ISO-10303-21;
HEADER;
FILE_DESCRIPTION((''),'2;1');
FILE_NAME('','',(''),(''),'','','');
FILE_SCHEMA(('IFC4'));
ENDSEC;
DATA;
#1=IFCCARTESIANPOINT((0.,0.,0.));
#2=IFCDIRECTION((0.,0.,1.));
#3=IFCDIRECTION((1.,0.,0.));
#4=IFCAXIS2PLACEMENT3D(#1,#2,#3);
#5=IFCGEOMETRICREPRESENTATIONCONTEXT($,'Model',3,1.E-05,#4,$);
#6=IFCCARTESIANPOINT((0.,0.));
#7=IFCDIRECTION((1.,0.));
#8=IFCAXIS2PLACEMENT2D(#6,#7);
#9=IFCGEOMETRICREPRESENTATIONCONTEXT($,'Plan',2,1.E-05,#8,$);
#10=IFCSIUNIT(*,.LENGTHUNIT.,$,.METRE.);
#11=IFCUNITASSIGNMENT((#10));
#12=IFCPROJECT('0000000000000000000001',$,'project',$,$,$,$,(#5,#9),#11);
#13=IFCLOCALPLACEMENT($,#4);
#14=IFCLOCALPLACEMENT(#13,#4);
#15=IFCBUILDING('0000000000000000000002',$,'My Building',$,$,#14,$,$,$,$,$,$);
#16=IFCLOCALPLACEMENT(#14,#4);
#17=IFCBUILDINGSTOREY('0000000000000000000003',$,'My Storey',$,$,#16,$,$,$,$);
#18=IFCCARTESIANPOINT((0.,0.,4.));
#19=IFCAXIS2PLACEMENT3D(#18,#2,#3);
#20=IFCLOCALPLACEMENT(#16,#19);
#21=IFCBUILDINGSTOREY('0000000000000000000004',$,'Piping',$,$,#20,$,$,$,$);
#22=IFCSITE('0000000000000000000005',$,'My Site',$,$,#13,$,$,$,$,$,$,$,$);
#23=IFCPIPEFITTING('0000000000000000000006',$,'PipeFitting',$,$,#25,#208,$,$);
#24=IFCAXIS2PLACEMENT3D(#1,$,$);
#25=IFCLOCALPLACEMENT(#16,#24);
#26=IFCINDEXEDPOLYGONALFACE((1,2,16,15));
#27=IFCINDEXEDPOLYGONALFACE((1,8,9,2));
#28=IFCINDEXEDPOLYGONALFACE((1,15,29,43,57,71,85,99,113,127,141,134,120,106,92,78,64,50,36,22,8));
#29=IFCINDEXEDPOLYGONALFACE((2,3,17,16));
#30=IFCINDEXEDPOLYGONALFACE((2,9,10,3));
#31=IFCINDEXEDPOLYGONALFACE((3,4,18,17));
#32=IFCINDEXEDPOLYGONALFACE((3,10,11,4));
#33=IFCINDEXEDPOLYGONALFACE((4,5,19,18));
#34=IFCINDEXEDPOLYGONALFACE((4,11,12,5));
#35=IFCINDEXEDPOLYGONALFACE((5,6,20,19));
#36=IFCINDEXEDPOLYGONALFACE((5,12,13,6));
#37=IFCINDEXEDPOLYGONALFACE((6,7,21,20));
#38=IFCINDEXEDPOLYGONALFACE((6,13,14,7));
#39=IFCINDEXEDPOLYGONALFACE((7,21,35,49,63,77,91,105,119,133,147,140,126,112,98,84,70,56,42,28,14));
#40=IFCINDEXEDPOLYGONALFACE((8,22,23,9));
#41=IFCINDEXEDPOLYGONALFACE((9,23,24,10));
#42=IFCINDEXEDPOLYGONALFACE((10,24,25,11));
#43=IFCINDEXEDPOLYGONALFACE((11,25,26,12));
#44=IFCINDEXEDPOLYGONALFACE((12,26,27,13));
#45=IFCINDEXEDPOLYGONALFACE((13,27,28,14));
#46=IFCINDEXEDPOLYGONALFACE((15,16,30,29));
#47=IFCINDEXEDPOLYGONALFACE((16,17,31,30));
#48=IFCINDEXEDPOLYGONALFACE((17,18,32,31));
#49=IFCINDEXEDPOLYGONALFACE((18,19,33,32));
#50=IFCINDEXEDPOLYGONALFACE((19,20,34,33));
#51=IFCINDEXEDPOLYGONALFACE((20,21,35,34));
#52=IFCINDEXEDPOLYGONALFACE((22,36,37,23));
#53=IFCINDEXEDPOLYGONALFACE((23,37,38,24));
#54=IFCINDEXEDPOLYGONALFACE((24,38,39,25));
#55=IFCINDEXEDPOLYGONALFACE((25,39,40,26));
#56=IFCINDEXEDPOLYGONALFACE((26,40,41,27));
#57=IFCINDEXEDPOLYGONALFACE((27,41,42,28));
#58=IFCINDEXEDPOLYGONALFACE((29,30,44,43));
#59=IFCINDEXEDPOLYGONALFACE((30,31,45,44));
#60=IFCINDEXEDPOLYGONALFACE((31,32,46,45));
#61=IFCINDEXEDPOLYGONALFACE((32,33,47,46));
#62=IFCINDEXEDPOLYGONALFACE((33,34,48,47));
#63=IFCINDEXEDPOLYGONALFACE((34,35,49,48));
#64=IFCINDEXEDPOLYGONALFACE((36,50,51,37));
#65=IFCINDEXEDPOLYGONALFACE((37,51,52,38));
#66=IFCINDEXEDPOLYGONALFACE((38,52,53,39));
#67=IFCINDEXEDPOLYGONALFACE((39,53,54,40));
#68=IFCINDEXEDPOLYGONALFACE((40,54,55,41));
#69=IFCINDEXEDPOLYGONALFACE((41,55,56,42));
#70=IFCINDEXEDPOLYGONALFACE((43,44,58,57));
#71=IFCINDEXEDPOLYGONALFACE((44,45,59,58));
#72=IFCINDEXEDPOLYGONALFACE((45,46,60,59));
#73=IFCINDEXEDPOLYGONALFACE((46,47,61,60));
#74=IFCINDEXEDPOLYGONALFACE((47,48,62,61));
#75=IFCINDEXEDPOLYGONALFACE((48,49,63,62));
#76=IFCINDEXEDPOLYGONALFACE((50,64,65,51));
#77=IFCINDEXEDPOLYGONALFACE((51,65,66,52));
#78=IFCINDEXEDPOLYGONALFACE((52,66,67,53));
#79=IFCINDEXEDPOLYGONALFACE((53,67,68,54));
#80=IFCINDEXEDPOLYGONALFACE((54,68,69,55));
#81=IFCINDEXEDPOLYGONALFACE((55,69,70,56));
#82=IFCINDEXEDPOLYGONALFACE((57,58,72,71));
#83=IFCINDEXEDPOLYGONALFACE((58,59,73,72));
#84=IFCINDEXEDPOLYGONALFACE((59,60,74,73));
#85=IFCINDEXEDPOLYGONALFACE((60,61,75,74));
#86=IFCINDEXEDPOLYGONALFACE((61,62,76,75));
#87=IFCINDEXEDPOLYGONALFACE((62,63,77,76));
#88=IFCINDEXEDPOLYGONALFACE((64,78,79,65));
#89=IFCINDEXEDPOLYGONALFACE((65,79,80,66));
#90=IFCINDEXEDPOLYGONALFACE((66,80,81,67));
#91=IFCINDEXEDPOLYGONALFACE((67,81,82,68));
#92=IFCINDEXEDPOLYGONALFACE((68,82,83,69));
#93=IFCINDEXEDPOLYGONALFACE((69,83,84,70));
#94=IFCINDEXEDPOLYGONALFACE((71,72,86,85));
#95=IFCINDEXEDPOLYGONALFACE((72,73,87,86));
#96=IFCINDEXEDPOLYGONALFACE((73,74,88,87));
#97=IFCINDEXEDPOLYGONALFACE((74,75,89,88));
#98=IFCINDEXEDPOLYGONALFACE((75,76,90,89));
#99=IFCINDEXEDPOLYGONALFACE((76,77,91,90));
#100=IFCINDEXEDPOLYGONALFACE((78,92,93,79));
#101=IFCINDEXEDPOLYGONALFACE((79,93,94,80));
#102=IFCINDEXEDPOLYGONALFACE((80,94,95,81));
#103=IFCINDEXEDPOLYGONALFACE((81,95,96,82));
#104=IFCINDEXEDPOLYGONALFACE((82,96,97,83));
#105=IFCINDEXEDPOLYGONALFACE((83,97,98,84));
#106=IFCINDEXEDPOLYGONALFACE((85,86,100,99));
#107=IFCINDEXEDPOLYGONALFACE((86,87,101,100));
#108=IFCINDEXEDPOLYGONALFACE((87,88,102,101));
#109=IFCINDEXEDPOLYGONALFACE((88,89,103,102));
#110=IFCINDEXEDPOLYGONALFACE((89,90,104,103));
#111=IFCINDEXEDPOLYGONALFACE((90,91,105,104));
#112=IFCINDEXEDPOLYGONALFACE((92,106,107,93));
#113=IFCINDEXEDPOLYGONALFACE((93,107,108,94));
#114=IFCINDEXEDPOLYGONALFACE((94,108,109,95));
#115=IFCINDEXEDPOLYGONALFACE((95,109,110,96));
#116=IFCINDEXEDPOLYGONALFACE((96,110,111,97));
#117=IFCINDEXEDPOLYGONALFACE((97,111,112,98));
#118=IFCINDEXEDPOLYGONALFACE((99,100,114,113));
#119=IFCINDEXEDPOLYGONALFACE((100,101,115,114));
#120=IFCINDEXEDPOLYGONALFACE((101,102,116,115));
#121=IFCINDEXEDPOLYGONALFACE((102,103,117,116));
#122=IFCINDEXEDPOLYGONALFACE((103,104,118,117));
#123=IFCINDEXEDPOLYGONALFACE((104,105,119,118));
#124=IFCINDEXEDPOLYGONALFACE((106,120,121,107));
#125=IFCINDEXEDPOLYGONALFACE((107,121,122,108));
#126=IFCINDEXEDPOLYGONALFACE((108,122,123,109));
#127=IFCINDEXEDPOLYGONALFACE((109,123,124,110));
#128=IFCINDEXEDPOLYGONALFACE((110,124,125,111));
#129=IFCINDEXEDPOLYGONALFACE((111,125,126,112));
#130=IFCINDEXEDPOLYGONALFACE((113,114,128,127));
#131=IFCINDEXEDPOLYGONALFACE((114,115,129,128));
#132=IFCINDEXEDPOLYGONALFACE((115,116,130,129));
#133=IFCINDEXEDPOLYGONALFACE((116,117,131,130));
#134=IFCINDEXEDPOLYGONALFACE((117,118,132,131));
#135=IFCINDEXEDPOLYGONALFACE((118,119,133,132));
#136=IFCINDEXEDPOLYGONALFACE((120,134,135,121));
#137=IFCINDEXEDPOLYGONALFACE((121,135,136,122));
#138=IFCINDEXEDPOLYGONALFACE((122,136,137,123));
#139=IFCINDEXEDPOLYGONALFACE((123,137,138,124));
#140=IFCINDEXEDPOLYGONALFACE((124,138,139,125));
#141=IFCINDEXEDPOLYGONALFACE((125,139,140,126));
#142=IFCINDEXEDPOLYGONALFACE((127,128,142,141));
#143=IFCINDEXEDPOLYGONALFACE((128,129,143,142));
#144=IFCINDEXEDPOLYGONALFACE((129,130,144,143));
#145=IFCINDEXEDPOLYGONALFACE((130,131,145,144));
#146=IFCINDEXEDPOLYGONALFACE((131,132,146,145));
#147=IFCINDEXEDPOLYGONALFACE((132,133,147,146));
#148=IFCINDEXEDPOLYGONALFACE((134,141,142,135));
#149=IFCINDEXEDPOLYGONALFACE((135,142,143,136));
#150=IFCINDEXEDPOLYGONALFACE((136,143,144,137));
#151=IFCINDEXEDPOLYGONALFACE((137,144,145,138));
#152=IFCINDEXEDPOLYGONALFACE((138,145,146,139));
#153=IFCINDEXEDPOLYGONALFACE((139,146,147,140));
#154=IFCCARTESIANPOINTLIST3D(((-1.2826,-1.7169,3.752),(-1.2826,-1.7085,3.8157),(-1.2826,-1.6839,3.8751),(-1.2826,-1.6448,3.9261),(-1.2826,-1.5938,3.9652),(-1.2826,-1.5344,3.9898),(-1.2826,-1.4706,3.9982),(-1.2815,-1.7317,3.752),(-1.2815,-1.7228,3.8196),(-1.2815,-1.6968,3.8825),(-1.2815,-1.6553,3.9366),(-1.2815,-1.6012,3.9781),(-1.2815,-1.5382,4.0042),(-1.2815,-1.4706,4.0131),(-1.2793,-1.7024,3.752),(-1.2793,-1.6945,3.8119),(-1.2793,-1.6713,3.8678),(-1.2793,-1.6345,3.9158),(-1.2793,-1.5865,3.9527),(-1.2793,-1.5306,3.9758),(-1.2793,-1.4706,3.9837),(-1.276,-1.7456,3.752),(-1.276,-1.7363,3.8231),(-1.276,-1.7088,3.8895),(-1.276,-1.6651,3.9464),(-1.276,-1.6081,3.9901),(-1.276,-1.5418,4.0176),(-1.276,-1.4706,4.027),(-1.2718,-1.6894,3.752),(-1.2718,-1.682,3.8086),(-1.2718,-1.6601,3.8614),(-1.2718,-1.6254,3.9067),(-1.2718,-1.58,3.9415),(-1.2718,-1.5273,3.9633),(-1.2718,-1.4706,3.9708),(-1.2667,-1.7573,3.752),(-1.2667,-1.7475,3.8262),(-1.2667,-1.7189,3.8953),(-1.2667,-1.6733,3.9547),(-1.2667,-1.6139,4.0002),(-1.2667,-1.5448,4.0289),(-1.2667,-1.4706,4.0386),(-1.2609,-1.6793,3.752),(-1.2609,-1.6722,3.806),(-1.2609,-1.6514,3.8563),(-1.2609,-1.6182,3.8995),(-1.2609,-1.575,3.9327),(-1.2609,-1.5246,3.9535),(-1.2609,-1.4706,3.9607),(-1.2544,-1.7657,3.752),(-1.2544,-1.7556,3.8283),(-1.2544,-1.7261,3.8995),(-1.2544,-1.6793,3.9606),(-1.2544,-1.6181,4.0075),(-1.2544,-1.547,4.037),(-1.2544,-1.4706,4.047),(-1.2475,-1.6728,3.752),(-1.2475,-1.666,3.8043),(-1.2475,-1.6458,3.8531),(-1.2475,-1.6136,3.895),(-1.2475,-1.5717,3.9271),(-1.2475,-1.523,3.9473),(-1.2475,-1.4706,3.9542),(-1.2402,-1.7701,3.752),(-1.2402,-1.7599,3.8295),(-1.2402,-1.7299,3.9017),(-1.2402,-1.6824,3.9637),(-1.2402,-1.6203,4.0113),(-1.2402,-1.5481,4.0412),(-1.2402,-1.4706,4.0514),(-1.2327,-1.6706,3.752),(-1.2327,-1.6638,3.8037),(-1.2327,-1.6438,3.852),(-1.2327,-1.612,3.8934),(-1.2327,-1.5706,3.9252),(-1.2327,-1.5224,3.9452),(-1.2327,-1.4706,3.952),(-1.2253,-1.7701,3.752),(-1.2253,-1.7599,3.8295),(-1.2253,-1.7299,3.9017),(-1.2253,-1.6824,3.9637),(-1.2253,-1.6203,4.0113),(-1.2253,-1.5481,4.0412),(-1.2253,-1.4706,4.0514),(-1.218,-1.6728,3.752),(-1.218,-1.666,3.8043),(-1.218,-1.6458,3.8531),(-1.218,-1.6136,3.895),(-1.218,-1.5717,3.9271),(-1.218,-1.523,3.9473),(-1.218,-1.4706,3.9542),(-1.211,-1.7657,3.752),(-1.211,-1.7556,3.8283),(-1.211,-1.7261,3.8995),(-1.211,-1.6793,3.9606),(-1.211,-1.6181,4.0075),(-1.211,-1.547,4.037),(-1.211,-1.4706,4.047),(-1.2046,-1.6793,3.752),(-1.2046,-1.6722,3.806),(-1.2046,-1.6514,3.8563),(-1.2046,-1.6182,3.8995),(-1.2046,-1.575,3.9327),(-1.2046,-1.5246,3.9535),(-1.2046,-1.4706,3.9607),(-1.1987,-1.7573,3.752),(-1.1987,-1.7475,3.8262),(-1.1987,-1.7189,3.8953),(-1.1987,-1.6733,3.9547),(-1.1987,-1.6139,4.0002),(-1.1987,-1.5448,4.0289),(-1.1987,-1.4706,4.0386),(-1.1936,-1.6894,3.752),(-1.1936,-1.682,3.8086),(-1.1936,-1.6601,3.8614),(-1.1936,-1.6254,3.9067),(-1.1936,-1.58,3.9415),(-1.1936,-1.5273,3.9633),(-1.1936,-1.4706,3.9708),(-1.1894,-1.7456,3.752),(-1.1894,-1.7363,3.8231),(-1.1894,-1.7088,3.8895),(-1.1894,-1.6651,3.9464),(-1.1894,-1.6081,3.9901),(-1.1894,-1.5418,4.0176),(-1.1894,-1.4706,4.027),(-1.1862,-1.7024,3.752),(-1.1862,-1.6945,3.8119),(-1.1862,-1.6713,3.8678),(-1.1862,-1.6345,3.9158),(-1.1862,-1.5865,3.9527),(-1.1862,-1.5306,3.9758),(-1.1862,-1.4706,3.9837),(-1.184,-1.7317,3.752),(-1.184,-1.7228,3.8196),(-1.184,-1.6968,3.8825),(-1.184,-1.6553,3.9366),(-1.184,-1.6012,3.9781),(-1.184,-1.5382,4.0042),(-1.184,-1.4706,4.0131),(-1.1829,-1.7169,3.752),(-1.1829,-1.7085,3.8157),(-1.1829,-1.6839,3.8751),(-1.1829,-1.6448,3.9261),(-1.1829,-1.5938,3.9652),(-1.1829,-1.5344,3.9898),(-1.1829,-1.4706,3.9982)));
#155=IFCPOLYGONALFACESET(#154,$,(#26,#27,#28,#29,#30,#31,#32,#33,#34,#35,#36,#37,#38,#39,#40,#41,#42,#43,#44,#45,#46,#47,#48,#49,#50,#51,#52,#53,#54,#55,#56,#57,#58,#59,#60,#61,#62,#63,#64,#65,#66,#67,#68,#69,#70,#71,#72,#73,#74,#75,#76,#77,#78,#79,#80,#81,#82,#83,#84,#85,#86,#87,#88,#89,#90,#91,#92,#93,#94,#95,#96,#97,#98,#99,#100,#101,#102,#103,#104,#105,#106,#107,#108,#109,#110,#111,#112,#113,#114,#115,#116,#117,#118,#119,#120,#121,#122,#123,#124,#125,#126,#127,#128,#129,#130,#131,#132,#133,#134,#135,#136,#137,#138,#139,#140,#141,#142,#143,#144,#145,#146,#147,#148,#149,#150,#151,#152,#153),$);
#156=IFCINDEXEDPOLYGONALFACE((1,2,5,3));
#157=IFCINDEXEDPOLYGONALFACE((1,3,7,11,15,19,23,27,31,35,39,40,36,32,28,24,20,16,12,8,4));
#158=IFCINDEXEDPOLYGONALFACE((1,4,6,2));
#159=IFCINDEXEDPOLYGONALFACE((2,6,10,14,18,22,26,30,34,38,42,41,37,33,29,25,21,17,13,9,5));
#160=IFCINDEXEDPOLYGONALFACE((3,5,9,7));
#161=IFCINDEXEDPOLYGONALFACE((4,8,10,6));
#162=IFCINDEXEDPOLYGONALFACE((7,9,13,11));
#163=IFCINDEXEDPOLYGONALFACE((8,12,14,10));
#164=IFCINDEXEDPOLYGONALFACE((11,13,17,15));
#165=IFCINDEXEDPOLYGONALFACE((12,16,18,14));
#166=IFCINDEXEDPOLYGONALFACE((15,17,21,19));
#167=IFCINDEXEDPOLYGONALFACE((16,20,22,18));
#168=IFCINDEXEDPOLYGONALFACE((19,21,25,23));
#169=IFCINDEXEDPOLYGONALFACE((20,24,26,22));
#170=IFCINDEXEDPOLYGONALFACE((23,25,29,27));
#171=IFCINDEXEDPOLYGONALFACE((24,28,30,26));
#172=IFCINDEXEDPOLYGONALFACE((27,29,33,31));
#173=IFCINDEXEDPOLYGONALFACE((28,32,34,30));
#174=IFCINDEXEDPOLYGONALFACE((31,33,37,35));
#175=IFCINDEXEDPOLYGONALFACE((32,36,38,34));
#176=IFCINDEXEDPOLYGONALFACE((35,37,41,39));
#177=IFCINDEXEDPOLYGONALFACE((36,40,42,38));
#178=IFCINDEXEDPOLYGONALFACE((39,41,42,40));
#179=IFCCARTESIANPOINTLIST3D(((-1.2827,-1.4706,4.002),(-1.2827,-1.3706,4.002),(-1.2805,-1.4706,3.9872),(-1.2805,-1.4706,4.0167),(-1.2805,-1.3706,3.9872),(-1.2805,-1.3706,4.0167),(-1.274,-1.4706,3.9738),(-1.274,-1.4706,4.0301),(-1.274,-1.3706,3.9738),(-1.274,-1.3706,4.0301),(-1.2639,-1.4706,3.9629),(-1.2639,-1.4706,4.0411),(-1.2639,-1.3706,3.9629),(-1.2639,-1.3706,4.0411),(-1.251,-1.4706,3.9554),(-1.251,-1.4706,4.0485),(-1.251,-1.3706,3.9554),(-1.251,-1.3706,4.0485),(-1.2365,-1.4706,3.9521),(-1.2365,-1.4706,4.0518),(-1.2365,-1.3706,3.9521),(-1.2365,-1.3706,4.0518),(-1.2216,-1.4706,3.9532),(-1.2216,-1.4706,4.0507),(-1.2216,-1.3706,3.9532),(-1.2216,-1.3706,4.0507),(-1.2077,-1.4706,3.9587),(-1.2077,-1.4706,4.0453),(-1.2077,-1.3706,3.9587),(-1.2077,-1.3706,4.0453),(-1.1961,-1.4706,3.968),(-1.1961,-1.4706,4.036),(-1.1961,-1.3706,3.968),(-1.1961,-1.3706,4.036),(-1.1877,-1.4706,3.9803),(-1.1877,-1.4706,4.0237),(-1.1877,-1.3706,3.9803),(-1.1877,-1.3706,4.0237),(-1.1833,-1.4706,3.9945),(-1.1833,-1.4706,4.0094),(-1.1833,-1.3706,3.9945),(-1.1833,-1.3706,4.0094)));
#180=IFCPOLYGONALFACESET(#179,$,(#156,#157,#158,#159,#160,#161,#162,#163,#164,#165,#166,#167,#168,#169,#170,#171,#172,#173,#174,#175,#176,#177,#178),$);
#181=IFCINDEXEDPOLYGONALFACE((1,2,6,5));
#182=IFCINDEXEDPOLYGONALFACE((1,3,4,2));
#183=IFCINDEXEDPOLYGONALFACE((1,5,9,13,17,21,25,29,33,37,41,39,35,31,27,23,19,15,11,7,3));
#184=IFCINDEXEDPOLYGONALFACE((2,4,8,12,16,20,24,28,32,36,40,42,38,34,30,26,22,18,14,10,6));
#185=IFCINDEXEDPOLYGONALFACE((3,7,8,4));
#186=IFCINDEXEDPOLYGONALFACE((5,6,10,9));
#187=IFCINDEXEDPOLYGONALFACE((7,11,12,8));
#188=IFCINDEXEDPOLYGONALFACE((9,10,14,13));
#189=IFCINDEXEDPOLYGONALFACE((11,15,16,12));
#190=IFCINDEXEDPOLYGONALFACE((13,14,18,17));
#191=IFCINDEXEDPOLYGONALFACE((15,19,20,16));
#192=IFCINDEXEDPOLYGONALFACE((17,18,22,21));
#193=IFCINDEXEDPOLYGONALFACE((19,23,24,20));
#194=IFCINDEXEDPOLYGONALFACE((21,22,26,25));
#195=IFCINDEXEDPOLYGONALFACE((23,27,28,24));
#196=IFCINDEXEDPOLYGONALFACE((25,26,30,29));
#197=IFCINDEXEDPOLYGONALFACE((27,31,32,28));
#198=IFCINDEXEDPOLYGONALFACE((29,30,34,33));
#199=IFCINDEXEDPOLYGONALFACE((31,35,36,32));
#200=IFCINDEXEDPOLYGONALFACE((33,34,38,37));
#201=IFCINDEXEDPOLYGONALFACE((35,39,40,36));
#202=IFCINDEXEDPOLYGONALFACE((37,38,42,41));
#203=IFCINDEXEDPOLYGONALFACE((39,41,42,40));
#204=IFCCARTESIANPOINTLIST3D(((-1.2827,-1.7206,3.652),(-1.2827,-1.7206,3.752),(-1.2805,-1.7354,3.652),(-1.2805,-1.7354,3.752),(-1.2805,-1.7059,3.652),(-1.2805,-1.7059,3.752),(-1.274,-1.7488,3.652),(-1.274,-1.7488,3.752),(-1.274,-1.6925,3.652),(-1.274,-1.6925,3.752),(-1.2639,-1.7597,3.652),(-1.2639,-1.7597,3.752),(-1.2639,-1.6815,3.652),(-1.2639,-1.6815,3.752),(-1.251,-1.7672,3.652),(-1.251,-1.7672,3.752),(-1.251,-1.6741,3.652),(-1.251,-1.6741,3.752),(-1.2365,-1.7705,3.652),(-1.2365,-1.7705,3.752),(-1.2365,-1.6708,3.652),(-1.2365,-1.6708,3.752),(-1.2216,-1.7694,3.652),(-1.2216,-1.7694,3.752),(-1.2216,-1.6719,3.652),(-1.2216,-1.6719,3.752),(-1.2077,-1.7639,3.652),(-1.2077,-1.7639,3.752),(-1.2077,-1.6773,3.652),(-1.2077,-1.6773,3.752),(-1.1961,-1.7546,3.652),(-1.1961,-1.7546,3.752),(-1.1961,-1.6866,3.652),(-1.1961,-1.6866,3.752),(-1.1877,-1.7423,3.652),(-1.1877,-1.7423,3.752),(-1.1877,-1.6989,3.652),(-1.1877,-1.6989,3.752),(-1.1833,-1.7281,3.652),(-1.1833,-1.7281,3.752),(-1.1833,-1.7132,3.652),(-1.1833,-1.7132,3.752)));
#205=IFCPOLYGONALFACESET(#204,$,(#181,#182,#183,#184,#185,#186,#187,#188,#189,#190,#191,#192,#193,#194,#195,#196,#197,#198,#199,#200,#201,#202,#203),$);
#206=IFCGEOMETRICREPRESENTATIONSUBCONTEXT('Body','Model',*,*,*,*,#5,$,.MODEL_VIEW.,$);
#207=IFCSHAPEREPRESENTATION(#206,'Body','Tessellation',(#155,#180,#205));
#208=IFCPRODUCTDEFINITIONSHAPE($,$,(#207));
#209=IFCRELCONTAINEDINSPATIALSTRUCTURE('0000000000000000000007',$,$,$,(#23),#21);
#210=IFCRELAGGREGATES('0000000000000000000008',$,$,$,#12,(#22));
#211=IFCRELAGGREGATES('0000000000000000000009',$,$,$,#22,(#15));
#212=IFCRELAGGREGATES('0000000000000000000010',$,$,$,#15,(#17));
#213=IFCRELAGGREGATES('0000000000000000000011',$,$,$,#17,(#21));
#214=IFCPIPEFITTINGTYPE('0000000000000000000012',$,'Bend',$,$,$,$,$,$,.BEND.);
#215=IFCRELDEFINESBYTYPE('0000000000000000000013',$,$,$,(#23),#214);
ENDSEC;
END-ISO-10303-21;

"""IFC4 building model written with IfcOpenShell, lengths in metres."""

from ifc_helpers import new_model, entity, si_unit, frame, origin_with_axes, origin_2d_with_axis, place, context, subcontext, project, spatial, line, indexed_curve, circle, outline, extrude, source, transform, mapped, type_object, type_shapes, element, save


model = new_model("IFC4")

# Units and contexts
model_context = context("Model", 3, precision=1e-05, world=origin_with_axes())
plan_context = context("Plan", 2, precision=1e-05, world=origin_2d_with_axis())
body_context = subcontext(model_context, "Body", "Model", "MODEL_VIEW")
ifc_project = project(units=[si_unit("LENGTHUNIT", "METRE")], contexts=[model_context, plan_context])

# Site, building, storeys
site_placement = place(None, origin_with_axes())
site = spatial("IfcSite", under=ifc_project, at=site_placement, Name="My Site")
building_placement = place(site_placement, origin_with_axes())
building = spatial("IfcBuilding", under=site, at=building_placement, Name="My Building")
storey_1_placement = place(building_placement, origin_with_axes())
storey_1 = spatial("IfcBuildingStorey", under=building, at=storey_1_placement, Name="My Storey")
storey_2_placement = place(storey_1_placement, frame((0.0, 0.0, 4.0), z_axis=(0.0, 0.0, 1.0), x_axis=(1.0, 0.0, 0.0)))
storey_2 = spatial("IfcBuildingStorey", under=storey_1, at=storey_2_placement, Name="Piping")

# Shared definitions
pipe_fitting_type_1 = type_object("IfcPipeFittingType", Name="Bend", PredefinedType="BEND")
shared_shape = source(origin_with_axes(), body_context, "Body", "SolidModel", [
    entity("IfcSweptDiskSolid", entity("IfcIndexedPolyCurve", entity("IfcCartesianPointList3D", [[0.0, 0.0, -0.1], [0.0, -0.0732, -0.2768], [0.0, -0.25, -0.35]]), [entity("IfcArcIndex", [1, 2, 3])]), 0.05),
    extrude(circle(Radius=0.05), origin_with_axes(), (0.0, 0.0, -1.0), 0.1),
    extrude(circle(Radius=0.05), frame((0.0, -0.25, -0.35), z_axis=(0.0, -1.0, 0.0), x_axis=(1.0, 0.0, 0.0)), (0.0, 0.0, 1.0), 0.1),
])
type_shapes(pipe_fitting_type_1, [shared_shape])

# Pipe fitting, opening
pipe_fitting_1_placement = place(storey_2_placement, frame((-1.2327, -1.3706, 0.002), z_axis=(0.0, 1.0, 0.000001), x_axis=(-1.0, 0.0, 0.0)))
pipe_fitting_1 = element("IfcPipeFitting", 1, at=pipe_fitting_1_placement, inside=storey_2, type_object=pipe_fitting_type_1, Name="PipeFitting", context=body_context, shape_type="MappedRepresentation", body=[
    mapped(shared_shape, transform((0.0, 0.0, 0.0), x_axis=(1.0, 0.0, 0.0), y_axis=(0.0, 1.0, 0.0), z_axis=(0.0, 0.0, 1.0), scale=1.0)),
])
opening_1_placement = place(pipe_fitting_1_placement, frame((1.4634, -12.1995, 2.2344), z_axis=(0.0, 1.0, 0.000001), x_axis=(-1.0, 0.0, 0.0)))
element("IfcOpeningElement", 2, at=opening_1_placement, cuts=pipe_fitting_1, PredefinedType="OPENING", context=body_context, shape_type="SweptSolid", body=[
    extrude(outline(indexed_curve([(0.0, 0.0), (0.5, 0.0), (0.5, 0.5), (0.0, 0.5)], segments=[line(1, 2, 3, 4, 1)])), origin_with_axes(), (0.0, 0.0, 1.0), 0.5),
])

save(model, "model.ifc")
